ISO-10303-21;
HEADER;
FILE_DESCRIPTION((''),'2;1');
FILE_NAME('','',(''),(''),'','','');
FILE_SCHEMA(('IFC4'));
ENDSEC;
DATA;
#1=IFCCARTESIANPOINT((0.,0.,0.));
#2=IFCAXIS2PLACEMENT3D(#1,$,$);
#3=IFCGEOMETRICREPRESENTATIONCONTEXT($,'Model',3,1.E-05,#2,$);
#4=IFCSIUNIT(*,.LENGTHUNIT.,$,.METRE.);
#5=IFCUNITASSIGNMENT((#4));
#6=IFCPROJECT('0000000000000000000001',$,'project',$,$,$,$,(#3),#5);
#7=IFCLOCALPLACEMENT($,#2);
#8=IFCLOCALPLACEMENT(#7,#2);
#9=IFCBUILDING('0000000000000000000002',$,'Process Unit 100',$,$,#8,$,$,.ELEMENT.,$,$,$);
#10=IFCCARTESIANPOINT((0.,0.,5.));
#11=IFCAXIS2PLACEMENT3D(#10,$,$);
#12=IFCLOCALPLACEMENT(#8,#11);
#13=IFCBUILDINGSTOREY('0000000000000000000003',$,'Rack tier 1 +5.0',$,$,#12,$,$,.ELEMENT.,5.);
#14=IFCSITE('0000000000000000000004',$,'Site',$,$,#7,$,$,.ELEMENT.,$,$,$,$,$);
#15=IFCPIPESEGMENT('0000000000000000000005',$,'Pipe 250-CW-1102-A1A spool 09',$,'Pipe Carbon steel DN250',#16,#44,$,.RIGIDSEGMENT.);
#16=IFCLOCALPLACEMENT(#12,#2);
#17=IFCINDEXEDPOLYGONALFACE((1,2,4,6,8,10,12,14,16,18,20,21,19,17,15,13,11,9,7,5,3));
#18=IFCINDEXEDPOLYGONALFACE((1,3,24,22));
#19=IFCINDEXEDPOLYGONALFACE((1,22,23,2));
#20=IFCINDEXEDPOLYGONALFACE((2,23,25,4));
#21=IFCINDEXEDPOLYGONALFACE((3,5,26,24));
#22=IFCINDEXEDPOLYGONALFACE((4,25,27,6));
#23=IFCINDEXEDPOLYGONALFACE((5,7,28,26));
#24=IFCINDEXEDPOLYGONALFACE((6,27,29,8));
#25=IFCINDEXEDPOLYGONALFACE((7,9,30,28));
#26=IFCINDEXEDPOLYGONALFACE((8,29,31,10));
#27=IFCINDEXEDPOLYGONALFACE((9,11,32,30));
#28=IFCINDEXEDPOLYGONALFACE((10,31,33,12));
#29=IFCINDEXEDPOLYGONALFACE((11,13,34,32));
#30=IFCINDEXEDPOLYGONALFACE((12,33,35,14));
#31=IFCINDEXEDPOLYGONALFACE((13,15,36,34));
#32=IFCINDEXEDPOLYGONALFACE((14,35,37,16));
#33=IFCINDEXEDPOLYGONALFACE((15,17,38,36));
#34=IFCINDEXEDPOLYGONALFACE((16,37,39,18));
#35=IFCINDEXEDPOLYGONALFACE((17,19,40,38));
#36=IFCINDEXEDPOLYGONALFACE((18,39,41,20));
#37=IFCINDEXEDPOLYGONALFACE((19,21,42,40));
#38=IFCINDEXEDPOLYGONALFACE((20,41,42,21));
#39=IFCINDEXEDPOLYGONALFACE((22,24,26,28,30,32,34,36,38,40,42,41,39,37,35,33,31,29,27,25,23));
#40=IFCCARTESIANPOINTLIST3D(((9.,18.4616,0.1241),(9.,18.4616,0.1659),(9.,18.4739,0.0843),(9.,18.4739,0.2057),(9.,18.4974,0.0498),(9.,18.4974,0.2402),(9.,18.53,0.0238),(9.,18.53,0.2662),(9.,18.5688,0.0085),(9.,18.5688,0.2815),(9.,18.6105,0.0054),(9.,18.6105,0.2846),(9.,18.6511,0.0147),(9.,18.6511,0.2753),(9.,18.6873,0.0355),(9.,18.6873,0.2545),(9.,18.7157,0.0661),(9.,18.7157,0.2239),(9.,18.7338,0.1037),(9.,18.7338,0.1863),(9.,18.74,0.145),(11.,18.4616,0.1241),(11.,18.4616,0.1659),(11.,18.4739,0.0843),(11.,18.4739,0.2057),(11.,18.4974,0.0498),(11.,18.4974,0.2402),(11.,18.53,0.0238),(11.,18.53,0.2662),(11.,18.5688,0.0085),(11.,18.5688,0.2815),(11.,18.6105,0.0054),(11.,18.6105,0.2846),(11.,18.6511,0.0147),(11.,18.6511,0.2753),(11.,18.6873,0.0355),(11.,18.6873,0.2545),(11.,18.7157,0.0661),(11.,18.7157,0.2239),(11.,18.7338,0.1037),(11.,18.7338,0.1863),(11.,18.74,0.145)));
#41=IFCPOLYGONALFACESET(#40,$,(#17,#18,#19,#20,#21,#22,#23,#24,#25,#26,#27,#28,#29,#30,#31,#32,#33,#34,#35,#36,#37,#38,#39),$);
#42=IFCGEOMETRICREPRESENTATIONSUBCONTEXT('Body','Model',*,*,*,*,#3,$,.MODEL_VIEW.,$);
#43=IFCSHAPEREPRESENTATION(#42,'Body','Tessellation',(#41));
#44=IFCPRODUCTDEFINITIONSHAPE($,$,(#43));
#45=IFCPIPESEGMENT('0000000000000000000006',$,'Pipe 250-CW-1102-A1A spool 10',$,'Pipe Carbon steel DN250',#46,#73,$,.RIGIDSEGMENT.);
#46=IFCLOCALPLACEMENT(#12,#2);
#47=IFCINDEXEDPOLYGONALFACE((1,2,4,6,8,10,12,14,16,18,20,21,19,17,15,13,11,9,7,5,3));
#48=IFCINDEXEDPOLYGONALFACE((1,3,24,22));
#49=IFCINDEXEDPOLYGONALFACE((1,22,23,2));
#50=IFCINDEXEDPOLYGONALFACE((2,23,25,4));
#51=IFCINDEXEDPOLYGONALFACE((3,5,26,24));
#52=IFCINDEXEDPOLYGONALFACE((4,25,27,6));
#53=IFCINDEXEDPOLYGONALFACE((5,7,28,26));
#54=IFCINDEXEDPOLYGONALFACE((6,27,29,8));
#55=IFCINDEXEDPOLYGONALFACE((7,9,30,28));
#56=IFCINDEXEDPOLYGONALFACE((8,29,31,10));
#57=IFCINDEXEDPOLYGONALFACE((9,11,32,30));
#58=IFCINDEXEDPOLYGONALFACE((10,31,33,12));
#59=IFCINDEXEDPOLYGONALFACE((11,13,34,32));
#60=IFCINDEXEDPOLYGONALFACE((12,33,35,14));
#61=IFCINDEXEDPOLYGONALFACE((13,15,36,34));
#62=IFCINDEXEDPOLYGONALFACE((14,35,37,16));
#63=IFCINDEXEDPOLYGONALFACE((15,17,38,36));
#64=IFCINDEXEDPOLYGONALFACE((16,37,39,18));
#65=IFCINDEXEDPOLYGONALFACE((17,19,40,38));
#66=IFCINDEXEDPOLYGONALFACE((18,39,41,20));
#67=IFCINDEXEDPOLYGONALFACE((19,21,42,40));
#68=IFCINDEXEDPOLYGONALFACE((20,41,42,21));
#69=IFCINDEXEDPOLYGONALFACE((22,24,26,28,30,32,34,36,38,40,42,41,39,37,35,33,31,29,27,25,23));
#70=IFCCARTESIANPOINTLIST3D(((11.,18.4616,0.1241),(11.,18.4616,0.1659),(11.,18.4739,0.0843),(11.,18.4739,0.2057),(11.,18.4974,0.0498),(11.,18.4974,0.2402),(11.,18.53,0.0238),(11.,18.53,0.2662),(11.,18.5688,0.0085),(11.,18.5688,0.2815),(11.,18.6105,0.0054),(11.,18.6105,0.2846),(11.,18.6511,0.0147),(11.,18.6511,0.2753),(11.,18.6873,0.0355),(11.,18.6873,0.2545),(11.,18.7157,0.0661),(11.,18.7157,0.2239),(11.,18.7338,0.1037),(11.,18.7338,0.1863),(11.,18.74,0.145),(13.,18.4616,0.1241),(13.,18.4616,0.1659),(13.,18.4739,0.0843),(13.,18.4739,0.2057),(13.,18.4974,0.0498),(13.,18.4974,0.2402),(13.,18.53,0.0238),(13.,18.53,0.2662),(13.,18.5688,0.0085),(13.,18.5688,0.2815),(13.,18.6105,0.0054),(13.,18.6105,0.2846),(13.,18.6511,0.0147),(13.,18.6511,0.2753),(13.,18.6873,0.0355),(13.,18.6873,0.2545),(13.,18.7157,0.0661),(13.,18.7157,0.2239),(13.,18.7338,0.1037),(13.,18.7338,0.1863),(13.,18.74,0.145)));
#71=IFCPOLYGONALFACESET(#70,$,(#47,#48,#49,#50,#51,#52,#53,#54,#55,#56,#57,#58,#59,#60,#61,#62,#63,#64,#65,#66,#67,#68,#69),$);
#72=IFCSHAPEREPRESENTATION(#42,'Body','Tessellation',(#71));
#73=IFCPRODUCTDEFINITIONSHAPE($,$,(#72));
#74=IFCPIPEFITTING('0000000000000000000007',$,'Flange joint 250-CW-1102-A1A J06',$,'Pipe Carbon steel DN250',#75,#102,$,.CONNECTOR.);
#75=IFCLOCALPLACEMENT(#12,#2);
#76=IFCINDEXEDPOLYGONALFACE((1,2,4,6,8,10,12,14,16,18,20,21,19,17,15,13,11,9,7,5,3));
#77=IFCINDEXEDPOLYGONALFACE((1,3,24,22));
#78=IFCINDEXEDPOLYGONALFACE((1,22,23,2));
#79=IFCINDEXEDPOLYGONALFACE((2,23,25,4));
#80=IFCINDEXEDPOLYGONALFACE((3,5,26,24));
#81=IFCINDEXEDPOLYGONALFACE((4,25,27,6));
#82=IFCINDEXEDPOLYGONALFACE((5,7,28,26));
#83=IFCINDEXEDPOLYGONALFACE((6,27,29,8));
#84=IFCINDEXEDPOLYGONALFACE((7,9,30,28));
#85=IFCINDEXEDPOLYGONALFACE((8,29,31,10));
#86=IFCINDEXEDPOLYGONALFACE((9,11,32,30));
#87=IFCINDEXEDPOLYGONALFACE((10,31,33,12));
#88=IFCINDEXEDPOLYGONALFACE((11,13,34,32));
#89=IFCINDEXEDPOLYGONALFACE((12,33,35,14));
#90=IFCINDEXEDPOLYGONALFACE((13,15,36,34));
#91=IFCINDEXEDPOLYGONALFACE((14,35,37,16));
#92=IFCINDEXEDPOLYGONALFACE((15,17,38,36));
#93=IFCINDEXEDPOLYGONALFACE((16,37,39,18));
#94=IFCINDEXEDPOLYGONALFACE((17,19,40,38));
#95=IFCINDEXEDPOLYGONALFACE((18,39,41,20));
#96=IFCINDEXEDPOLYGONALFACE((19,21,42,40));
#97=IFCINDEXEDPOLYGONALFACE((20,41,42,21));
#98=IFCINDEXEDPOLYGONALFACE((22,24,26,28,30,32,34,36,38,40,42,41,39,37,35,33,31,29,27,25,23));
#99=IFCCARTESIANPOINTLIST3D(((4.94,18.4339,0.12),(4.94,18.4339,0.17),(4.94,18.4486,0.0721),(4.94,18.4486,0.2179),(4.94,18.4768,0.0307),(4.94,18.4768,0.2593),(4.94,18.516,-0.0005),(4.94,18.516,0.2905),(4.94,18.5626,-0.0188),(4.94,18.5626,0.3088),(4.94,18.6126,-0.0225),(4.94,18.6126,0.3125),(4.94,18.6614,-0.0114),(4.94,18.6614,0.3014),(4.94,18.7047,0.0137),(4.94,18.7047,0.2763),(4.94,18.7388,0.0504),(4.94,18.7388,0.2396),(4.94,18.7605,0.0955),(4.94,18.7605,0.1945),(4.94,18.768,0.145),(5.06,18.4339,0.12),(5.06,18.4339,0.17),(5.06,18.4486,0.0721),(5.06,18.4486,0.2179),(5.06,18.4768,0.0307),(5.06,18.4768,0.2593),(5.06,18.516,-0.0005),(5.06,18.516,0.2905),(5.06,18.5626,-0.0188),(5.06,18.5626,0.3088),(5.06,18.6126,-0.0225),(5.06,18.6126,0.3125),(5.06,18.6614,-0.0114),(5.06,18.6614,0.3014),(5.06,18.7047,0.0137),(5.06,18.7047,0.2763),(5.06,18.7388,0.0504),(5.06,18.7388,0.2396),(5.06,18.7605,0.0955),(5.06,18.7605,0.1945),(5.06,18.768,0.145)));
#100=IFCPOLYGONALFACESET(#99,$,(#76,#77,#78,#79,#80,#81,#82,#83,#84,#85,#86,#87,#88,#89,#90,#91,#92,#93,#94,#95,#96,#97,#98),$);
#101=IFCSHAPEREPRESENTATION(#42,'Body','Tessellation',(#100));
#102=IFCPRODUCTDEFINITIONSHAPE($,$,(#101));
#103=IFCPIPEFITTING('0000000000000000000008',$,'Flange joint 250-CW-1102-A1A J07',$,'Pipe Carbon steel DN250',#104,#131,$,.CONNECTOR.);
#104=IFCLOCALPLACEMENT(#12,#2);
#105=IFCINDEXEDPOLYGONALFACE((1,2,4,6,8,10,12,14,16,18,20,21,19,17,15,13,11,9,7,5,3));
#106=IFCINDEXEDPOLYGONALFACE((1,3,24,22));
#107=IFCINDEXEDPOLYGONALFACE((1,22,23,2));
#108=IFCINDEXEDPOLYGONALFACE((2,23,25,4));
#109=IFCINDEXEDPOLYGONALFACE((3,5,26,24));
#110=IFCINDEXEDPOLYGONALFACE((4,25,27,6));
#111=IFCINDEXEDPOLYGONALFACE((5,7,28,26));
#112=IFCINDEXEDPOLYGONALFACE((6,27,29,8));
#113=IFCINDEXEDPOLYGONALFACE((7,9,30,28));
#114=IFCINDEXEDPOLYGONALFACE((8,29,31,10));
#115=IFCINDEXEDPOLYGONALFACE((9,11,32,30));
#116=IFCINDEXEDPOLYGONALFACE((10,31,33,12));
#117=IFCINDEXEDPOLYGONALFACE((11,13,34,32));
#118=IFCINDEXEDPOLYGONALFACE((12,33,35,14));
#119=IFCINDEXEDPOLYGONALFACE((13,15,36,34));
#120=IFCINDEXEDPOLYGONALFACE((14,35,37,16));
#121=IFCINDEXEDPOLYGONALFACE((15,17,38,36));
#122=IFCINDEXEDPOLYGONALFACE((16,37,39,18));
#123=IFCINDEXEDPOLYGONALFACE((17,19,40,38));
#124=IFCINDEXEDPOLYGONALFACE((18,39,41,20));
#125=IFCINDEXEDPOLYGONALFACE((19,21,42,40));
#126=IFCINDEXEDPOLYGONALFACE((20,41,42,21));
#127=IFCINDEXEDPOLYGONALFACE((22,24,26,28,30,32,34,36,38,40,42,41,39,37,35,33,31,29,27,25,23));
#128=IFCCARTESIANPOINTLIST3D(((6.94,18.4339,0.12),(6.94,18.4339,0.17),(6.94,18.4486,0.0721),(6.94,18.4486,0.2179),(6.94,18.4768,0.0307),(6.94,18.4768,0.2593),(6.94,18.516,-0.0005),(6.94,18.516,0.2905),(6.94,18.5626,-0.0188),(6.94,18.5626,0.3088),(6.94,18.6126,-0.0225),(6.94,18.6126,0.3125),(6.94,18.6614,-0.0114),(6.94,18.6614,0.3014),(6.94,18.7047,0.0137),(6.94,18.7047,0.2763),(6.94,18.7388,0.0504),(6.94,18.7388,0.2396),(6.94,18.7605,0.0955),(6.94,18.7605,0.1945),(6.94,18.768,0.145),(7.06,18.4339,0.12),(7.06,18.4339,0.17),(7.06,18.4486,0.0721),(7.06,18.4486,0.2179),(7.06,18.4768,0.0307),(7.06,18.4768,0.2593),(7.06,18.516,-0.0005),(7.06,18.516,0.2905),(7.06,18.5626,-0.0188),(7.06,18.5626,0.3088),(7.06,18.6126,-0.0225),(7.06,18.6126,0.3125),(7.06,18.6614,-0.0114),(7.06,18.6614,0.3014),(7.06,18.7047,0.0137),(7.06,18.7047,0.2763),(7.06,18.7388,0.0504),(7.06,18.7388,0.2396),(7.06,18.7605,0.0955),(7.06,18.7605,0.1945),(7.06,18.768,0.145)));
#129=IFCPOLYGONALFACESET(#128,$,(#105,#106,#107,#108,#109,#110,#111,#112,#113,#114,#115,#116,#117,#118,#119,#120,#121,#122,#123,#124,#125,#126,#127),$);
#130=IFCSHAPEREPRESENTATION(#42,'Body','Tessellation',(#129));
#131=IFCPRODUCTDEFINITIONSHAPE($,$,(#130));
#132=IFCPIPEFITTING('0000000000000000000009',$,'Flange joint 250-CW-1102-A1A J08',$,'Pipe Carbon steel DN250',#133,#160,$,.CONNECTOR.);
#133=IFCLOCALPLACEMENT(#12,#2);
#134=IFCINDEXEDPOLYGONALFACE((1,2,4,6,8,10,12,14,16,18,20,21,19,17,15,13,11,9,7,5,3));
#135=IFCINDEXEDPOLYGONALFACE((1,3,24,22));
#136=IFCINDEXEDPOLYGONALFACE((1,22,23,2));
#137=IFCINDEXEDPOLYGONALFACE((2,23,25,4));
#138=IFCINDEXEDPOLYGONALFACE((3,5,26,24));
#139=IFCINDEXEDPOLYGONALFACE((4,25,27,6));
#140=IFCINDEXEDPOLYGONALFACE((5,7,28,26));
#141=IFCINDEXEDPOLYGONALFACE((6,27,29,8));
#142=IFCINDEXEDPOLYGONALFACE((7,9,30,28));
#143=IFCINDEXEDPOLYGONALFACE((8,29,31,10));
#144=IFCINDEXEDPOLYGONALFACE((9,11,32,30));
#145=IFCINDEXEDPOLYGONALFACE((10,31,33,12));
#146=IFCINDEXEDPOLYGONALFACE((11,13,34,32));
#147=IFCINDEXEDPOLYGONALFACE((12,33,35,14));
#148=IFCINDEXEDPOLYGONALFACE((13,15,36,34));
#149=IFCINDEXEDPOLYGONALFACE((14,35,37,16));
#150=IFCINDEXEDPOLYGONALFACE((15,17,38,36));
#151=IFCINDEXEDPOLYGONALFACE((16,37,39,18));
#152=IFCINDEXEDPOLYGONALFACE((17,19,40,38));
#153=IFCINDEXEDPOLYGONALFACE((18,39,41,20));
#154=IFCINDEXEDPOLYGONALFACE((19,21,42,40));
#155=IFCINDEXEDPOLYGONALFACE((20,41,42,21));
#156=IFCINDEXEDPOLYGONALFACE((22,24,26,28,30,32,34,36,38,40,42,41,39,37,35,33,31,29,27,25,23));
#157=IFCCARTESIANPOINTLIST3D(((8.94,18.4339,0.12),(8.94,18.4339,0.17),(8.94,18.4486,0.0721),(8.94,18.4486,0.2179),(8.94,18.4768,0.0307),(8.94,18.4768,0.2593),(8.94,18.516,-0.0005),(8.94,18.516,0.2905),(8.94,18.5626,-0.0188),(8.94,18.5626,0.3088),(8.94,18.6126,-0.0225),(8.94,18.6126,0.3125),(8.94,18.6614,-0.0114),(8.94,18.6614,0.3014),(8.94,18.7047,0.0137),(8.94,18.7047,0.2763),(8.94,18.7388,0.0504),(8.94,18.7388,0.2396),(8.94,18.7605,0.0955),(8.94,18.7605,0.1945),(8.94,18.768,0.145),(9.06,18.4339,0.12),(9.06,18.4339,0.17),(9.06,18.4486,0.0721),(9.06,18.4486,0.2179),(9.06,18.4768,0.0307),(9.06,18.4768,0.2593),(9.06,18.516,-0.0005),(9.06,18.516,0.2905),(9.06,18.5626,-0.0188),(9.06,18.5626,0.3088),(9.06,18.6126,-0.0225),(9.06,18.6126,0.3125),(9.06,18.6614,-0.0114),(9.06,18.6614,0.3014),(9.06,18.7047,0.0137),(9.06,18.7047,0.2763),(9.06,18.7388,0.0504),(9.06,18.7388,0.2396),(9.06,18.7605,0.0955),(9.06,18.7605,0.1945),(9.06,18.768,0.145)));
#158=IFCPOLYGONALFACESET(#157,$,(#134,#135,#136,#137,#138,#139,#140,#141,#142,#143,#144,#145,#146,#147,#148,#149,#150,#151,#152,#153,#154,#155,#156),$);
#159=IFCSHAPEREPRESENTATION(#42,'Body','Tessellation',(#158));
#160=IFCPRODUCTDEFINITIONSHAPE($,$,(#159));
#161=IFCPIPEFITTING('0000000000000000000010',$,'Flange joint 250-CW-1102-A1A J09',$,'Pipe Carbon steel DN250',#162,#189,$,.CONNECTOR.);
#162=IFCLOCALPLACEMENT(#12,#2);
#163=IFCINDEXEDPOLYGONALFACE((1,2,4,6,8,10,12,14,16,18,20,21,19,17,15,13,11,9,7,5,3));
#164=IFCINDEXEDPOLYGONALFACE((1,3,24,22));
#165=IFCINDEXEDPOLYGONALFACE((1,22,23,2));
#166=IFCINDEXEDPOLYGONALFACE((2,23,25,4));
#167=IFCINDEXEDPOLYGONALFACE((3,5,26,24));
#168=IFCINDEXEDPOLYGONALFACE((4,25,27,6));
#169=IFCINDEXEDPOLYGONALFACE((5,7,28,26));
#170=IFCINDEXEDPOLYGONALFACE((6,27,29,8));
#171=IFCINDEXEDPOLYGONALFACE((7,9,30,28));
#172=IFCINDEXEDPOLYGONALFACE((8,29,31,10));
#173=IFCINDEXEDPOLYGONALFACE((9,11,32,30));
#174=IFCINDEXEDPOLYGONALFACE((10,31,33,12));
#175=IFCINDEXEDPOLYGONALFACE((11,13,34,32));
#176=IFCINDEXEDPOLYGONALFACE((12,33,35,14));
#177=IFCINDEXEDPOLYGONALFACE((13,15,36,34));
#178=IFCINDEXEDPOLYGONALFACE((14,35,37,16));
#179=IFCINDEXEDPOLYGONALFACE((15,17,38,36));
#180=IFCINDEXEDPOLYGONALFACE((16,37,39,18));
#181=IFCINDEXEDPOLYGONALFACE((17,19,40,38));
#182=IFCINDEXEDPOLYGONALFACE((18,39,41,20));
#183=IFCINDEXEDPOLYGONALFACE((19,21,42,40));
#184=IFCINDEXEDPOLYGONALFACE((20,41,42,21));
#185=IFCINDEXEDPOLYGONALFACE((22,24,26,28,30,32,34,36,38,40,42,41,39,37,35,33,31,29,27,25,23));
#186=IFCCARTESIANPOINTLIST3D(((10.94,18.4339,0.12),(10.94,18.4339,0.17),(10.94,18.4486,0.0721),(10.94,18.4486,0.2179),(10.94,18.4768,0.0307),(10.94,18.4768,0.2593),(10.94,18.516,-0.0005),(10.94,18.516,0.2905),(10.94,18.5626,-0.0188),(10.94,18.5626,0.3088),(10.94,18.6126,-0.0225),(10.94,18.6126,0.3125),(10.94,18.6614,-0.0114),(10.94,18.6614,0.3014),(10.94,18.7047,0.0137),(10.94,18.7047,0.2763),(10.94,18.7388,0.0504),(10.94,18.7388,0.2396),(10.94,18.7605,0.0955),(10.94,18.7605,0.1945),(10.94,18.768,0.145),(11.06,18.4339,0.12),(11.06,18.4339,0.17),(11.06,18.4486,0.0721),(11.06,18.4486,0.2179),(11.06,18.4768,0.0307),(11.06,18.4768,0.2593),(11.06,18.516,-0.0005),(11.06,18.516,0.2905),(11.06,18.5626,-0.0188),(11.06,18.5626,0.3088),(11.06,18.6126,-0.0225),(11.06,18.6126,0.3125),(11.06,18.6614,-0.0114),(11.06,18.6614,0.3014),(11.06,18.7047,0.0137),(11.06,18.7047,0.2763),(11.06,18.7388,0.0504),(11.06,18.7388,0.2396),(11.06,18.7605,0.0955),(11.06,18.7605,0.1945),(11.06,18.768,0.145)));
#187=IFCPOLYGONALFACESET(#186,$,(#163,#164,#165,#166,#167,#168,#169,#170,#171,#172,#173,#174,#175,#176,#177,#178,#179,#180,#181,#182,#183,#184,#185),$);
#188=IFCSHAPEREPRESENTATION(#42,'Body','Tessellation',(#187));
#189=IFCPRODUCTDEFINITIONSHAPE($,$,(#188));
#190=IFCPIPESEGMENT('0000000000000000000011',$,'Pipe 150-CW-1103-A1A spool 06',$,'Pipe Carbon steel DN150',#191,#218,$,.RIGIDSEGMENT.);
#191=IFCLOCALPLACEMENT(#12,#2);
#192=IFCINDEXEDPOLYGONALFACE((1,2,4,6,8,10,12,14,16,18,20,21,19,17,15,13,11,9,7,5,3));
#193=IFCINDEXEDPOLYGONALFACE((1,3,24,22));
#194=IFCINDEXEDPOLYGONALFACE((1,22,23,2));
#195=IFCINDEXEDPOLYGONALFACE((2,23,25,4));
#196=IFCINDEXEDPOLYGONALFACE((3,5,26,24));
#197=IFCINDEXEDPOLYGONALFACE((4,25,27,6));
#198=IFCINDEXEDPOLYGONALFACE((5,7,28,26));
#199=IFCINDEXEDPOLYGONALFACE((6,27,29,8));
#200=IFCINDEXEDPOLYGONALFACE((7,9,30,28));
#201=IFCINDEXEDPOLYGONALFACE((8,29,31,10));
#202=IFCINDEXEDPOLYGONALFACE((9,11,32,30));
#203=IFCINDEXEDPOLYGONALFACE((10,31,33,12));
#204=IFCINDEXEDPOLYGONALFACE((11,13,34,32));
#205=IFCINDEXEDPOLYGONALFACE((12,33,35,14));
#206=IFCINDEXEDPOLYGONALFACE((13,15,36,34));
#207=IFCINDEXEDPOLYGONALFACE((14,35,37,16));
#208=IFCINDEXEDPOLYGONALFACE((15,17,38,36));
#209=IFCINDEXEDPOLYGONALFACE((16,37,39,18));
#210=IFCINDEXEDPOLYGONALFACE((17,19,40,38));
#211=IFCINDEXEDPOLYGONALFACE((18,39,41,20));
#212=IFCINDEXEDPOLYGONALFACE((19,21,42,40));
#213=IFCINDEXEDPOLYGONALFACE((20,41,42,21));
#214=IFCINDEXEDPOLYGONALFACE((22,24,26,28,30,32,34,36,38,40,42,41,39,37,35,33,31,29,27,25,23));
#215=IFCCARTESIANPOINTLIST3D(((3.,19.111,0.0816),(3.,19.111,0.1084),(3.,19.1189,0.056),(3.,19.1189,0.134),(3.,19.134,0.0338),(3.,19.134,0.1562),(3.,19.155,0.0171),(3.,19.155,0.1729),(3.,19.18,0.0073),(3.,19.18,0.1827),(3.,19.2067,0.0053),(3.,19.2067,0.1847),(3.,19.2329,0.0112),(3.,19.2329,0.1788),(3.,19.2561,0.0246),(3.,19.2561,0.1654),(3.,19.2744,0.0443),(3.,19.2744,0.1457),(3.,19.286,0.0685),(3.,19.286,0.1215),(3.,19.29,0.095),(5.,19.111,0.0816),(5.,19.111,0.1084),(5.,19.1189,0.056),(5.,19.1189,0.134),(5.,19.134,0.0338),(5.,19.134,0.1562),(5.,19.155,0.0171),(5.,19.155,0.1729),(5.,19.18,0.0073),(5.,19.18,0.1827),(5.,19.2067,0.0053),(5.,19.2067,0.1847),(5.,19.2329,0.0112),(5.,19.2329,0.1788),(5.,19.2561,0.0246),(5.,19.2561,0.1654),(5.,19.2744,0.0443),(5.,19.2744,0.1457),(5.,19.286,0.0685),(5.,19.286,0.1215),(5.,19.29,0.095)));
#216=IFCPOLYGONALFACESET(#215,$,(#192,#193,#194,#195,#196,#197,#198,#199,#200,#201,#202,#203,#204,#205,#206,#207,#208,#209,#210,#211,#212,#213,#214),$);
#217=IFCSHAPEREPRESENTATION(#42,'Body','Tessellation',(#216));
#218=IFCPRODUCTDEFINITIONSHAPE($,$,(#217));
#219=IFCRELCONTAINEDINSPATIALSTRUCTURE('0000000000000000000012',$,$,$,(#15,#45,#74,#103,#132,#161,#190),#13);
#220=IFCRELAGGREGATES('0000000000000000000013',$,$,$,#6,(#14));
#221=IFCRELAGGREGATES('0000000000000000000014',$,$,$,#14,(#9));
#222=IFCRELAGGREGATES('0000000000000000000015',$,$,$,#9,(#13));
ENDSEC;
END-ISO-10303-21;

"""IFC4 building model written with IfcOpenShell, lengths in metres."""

from ifc_helpers import new_model, si_unit, frame, origin, place, context, subcontext, project, spatial, circle, extrude, element, save


model = new_model("IFC4")

# Units and contexts
model_context = context("Model", 3, precision=1e-05, world=origin())
body_context = subcontext(model_context, "Body", "Model", "MODEL_VIEW")
ifc_project = project(units=[si_unit("LENGTHUNIT", "METRE")], contexts=[model_context])

# Site, building, storey
site_placement = place(None, origin())
site = spatial("IfcSite", under=ifc_project, at=site_placement, Name="Site", CompositionType="ELEMENT")
building_placement = place(site_placement, origin())
building = spatial("IfcBuilding", under=site, at=building_placement, Name="Process Unit 100", CompositionType="ELEMENT")
storey_placement = place(building_placement, frame((0.0, 0.0, 5.0)))
storey = spatial("IfcBuildingStorey", under=building, at=storey_placement, Name="Rack tier 1 +5.0", CompositionType="ELEMENT", Elevation=5.0)

# Pipe segments
for number, where, z_axis, x_axis, name in (
    (1, (9.0, 18.6, 0.145), (1.0, 0.0, 0.0), (0.0, 1.0, 0.0), "Pipe 250-CW-1102-A1A spool 09"),
    (2, (11.0, 18.6, 0.145), (1.0, 0.0, 0.0), (0.0, 1.0, 0.0), "Pipe 250-CW-1102-A1A spool 10"),
):
    element("IfcPipeSegment", number, at=place(storey_placement, frame(where, z_axis=z_axis, x_axis=x_axis)), inside=storey, Name=name, ObjectType="Pipe Carbon steel DN250", PredefinedType="RIGIDSEGMENT", context=body_context, shape_type="SweptSolid", body=[
        extrude(circle(Radius=0.14), origin(), (0.0, 0.0, 1.0), 2.0),
    ])

# Pipe fittings
for number, where, z_axis, x_axis, name in (
    (3, (4.94, 18.6, 0.145), (1.0, 0.0, 0.0), (0.0, 1.0, 0.0), "Flange joint 250-CW-1102-A1A J06"),
    (4, (6.94, 18.6, 0.145), (1.0, 0.0, 0.0), (0.0, 1.0, 0.0), "Flange joint 250-CW-1102-A1A J07"),
    (5, (8.94, 18.6, 0.145), (1.0, 0.0, 0.0), (0.0, 1.0, 0.0), "Flange joint 250-CW-1102-A1A J08"),
    (6, (10.94, 18.6, 0.145), (1.0, 0.0, 0.0), (0.0, 1.0, 0.0), "Flange joint 250-CW-1102-A1A J09"),
):
    element("IfcPipeFitting", number, at=place(storey_placement, frame(where, z_axis=z_axis, x_axis=x_axis)), inside=storey, Name=name, ObjectType="Pipe Carbon steel DN250", PredefinedType="CONNECTOR", context=body_context, shape_type="SweptSolid", body=[
        extrude(circle(Radius=0.168), origin(), (0.0, 0.0, 1.0), 0.12),
    ])

# Pipe segment
for number, where, z_axis, x_axis, name in (
    (7, (3.0, 19.2, 0.095), (1.0, 0.0, 0.0), (0.0, 1.0, 0.0), "Pipe 150-CW-1103-A1A spool 06"),
):
    element("IfcPipeSegment", number, at=place(storey_placement, frame(where, z_axis=z_axis, x_axis=x_axis)), inside=storey, Name=name, ObjectType="Pipe Carbon steel DN150", PredefinedType="RIGIDSEGMENT", context=body_context, shape_type="SweptSolid", body=[
        extrude(circle(Radius=0.09), origin(), (0.0, 0.0, 1.0), 2.0),
    ])

save(model, "model.ifc")
